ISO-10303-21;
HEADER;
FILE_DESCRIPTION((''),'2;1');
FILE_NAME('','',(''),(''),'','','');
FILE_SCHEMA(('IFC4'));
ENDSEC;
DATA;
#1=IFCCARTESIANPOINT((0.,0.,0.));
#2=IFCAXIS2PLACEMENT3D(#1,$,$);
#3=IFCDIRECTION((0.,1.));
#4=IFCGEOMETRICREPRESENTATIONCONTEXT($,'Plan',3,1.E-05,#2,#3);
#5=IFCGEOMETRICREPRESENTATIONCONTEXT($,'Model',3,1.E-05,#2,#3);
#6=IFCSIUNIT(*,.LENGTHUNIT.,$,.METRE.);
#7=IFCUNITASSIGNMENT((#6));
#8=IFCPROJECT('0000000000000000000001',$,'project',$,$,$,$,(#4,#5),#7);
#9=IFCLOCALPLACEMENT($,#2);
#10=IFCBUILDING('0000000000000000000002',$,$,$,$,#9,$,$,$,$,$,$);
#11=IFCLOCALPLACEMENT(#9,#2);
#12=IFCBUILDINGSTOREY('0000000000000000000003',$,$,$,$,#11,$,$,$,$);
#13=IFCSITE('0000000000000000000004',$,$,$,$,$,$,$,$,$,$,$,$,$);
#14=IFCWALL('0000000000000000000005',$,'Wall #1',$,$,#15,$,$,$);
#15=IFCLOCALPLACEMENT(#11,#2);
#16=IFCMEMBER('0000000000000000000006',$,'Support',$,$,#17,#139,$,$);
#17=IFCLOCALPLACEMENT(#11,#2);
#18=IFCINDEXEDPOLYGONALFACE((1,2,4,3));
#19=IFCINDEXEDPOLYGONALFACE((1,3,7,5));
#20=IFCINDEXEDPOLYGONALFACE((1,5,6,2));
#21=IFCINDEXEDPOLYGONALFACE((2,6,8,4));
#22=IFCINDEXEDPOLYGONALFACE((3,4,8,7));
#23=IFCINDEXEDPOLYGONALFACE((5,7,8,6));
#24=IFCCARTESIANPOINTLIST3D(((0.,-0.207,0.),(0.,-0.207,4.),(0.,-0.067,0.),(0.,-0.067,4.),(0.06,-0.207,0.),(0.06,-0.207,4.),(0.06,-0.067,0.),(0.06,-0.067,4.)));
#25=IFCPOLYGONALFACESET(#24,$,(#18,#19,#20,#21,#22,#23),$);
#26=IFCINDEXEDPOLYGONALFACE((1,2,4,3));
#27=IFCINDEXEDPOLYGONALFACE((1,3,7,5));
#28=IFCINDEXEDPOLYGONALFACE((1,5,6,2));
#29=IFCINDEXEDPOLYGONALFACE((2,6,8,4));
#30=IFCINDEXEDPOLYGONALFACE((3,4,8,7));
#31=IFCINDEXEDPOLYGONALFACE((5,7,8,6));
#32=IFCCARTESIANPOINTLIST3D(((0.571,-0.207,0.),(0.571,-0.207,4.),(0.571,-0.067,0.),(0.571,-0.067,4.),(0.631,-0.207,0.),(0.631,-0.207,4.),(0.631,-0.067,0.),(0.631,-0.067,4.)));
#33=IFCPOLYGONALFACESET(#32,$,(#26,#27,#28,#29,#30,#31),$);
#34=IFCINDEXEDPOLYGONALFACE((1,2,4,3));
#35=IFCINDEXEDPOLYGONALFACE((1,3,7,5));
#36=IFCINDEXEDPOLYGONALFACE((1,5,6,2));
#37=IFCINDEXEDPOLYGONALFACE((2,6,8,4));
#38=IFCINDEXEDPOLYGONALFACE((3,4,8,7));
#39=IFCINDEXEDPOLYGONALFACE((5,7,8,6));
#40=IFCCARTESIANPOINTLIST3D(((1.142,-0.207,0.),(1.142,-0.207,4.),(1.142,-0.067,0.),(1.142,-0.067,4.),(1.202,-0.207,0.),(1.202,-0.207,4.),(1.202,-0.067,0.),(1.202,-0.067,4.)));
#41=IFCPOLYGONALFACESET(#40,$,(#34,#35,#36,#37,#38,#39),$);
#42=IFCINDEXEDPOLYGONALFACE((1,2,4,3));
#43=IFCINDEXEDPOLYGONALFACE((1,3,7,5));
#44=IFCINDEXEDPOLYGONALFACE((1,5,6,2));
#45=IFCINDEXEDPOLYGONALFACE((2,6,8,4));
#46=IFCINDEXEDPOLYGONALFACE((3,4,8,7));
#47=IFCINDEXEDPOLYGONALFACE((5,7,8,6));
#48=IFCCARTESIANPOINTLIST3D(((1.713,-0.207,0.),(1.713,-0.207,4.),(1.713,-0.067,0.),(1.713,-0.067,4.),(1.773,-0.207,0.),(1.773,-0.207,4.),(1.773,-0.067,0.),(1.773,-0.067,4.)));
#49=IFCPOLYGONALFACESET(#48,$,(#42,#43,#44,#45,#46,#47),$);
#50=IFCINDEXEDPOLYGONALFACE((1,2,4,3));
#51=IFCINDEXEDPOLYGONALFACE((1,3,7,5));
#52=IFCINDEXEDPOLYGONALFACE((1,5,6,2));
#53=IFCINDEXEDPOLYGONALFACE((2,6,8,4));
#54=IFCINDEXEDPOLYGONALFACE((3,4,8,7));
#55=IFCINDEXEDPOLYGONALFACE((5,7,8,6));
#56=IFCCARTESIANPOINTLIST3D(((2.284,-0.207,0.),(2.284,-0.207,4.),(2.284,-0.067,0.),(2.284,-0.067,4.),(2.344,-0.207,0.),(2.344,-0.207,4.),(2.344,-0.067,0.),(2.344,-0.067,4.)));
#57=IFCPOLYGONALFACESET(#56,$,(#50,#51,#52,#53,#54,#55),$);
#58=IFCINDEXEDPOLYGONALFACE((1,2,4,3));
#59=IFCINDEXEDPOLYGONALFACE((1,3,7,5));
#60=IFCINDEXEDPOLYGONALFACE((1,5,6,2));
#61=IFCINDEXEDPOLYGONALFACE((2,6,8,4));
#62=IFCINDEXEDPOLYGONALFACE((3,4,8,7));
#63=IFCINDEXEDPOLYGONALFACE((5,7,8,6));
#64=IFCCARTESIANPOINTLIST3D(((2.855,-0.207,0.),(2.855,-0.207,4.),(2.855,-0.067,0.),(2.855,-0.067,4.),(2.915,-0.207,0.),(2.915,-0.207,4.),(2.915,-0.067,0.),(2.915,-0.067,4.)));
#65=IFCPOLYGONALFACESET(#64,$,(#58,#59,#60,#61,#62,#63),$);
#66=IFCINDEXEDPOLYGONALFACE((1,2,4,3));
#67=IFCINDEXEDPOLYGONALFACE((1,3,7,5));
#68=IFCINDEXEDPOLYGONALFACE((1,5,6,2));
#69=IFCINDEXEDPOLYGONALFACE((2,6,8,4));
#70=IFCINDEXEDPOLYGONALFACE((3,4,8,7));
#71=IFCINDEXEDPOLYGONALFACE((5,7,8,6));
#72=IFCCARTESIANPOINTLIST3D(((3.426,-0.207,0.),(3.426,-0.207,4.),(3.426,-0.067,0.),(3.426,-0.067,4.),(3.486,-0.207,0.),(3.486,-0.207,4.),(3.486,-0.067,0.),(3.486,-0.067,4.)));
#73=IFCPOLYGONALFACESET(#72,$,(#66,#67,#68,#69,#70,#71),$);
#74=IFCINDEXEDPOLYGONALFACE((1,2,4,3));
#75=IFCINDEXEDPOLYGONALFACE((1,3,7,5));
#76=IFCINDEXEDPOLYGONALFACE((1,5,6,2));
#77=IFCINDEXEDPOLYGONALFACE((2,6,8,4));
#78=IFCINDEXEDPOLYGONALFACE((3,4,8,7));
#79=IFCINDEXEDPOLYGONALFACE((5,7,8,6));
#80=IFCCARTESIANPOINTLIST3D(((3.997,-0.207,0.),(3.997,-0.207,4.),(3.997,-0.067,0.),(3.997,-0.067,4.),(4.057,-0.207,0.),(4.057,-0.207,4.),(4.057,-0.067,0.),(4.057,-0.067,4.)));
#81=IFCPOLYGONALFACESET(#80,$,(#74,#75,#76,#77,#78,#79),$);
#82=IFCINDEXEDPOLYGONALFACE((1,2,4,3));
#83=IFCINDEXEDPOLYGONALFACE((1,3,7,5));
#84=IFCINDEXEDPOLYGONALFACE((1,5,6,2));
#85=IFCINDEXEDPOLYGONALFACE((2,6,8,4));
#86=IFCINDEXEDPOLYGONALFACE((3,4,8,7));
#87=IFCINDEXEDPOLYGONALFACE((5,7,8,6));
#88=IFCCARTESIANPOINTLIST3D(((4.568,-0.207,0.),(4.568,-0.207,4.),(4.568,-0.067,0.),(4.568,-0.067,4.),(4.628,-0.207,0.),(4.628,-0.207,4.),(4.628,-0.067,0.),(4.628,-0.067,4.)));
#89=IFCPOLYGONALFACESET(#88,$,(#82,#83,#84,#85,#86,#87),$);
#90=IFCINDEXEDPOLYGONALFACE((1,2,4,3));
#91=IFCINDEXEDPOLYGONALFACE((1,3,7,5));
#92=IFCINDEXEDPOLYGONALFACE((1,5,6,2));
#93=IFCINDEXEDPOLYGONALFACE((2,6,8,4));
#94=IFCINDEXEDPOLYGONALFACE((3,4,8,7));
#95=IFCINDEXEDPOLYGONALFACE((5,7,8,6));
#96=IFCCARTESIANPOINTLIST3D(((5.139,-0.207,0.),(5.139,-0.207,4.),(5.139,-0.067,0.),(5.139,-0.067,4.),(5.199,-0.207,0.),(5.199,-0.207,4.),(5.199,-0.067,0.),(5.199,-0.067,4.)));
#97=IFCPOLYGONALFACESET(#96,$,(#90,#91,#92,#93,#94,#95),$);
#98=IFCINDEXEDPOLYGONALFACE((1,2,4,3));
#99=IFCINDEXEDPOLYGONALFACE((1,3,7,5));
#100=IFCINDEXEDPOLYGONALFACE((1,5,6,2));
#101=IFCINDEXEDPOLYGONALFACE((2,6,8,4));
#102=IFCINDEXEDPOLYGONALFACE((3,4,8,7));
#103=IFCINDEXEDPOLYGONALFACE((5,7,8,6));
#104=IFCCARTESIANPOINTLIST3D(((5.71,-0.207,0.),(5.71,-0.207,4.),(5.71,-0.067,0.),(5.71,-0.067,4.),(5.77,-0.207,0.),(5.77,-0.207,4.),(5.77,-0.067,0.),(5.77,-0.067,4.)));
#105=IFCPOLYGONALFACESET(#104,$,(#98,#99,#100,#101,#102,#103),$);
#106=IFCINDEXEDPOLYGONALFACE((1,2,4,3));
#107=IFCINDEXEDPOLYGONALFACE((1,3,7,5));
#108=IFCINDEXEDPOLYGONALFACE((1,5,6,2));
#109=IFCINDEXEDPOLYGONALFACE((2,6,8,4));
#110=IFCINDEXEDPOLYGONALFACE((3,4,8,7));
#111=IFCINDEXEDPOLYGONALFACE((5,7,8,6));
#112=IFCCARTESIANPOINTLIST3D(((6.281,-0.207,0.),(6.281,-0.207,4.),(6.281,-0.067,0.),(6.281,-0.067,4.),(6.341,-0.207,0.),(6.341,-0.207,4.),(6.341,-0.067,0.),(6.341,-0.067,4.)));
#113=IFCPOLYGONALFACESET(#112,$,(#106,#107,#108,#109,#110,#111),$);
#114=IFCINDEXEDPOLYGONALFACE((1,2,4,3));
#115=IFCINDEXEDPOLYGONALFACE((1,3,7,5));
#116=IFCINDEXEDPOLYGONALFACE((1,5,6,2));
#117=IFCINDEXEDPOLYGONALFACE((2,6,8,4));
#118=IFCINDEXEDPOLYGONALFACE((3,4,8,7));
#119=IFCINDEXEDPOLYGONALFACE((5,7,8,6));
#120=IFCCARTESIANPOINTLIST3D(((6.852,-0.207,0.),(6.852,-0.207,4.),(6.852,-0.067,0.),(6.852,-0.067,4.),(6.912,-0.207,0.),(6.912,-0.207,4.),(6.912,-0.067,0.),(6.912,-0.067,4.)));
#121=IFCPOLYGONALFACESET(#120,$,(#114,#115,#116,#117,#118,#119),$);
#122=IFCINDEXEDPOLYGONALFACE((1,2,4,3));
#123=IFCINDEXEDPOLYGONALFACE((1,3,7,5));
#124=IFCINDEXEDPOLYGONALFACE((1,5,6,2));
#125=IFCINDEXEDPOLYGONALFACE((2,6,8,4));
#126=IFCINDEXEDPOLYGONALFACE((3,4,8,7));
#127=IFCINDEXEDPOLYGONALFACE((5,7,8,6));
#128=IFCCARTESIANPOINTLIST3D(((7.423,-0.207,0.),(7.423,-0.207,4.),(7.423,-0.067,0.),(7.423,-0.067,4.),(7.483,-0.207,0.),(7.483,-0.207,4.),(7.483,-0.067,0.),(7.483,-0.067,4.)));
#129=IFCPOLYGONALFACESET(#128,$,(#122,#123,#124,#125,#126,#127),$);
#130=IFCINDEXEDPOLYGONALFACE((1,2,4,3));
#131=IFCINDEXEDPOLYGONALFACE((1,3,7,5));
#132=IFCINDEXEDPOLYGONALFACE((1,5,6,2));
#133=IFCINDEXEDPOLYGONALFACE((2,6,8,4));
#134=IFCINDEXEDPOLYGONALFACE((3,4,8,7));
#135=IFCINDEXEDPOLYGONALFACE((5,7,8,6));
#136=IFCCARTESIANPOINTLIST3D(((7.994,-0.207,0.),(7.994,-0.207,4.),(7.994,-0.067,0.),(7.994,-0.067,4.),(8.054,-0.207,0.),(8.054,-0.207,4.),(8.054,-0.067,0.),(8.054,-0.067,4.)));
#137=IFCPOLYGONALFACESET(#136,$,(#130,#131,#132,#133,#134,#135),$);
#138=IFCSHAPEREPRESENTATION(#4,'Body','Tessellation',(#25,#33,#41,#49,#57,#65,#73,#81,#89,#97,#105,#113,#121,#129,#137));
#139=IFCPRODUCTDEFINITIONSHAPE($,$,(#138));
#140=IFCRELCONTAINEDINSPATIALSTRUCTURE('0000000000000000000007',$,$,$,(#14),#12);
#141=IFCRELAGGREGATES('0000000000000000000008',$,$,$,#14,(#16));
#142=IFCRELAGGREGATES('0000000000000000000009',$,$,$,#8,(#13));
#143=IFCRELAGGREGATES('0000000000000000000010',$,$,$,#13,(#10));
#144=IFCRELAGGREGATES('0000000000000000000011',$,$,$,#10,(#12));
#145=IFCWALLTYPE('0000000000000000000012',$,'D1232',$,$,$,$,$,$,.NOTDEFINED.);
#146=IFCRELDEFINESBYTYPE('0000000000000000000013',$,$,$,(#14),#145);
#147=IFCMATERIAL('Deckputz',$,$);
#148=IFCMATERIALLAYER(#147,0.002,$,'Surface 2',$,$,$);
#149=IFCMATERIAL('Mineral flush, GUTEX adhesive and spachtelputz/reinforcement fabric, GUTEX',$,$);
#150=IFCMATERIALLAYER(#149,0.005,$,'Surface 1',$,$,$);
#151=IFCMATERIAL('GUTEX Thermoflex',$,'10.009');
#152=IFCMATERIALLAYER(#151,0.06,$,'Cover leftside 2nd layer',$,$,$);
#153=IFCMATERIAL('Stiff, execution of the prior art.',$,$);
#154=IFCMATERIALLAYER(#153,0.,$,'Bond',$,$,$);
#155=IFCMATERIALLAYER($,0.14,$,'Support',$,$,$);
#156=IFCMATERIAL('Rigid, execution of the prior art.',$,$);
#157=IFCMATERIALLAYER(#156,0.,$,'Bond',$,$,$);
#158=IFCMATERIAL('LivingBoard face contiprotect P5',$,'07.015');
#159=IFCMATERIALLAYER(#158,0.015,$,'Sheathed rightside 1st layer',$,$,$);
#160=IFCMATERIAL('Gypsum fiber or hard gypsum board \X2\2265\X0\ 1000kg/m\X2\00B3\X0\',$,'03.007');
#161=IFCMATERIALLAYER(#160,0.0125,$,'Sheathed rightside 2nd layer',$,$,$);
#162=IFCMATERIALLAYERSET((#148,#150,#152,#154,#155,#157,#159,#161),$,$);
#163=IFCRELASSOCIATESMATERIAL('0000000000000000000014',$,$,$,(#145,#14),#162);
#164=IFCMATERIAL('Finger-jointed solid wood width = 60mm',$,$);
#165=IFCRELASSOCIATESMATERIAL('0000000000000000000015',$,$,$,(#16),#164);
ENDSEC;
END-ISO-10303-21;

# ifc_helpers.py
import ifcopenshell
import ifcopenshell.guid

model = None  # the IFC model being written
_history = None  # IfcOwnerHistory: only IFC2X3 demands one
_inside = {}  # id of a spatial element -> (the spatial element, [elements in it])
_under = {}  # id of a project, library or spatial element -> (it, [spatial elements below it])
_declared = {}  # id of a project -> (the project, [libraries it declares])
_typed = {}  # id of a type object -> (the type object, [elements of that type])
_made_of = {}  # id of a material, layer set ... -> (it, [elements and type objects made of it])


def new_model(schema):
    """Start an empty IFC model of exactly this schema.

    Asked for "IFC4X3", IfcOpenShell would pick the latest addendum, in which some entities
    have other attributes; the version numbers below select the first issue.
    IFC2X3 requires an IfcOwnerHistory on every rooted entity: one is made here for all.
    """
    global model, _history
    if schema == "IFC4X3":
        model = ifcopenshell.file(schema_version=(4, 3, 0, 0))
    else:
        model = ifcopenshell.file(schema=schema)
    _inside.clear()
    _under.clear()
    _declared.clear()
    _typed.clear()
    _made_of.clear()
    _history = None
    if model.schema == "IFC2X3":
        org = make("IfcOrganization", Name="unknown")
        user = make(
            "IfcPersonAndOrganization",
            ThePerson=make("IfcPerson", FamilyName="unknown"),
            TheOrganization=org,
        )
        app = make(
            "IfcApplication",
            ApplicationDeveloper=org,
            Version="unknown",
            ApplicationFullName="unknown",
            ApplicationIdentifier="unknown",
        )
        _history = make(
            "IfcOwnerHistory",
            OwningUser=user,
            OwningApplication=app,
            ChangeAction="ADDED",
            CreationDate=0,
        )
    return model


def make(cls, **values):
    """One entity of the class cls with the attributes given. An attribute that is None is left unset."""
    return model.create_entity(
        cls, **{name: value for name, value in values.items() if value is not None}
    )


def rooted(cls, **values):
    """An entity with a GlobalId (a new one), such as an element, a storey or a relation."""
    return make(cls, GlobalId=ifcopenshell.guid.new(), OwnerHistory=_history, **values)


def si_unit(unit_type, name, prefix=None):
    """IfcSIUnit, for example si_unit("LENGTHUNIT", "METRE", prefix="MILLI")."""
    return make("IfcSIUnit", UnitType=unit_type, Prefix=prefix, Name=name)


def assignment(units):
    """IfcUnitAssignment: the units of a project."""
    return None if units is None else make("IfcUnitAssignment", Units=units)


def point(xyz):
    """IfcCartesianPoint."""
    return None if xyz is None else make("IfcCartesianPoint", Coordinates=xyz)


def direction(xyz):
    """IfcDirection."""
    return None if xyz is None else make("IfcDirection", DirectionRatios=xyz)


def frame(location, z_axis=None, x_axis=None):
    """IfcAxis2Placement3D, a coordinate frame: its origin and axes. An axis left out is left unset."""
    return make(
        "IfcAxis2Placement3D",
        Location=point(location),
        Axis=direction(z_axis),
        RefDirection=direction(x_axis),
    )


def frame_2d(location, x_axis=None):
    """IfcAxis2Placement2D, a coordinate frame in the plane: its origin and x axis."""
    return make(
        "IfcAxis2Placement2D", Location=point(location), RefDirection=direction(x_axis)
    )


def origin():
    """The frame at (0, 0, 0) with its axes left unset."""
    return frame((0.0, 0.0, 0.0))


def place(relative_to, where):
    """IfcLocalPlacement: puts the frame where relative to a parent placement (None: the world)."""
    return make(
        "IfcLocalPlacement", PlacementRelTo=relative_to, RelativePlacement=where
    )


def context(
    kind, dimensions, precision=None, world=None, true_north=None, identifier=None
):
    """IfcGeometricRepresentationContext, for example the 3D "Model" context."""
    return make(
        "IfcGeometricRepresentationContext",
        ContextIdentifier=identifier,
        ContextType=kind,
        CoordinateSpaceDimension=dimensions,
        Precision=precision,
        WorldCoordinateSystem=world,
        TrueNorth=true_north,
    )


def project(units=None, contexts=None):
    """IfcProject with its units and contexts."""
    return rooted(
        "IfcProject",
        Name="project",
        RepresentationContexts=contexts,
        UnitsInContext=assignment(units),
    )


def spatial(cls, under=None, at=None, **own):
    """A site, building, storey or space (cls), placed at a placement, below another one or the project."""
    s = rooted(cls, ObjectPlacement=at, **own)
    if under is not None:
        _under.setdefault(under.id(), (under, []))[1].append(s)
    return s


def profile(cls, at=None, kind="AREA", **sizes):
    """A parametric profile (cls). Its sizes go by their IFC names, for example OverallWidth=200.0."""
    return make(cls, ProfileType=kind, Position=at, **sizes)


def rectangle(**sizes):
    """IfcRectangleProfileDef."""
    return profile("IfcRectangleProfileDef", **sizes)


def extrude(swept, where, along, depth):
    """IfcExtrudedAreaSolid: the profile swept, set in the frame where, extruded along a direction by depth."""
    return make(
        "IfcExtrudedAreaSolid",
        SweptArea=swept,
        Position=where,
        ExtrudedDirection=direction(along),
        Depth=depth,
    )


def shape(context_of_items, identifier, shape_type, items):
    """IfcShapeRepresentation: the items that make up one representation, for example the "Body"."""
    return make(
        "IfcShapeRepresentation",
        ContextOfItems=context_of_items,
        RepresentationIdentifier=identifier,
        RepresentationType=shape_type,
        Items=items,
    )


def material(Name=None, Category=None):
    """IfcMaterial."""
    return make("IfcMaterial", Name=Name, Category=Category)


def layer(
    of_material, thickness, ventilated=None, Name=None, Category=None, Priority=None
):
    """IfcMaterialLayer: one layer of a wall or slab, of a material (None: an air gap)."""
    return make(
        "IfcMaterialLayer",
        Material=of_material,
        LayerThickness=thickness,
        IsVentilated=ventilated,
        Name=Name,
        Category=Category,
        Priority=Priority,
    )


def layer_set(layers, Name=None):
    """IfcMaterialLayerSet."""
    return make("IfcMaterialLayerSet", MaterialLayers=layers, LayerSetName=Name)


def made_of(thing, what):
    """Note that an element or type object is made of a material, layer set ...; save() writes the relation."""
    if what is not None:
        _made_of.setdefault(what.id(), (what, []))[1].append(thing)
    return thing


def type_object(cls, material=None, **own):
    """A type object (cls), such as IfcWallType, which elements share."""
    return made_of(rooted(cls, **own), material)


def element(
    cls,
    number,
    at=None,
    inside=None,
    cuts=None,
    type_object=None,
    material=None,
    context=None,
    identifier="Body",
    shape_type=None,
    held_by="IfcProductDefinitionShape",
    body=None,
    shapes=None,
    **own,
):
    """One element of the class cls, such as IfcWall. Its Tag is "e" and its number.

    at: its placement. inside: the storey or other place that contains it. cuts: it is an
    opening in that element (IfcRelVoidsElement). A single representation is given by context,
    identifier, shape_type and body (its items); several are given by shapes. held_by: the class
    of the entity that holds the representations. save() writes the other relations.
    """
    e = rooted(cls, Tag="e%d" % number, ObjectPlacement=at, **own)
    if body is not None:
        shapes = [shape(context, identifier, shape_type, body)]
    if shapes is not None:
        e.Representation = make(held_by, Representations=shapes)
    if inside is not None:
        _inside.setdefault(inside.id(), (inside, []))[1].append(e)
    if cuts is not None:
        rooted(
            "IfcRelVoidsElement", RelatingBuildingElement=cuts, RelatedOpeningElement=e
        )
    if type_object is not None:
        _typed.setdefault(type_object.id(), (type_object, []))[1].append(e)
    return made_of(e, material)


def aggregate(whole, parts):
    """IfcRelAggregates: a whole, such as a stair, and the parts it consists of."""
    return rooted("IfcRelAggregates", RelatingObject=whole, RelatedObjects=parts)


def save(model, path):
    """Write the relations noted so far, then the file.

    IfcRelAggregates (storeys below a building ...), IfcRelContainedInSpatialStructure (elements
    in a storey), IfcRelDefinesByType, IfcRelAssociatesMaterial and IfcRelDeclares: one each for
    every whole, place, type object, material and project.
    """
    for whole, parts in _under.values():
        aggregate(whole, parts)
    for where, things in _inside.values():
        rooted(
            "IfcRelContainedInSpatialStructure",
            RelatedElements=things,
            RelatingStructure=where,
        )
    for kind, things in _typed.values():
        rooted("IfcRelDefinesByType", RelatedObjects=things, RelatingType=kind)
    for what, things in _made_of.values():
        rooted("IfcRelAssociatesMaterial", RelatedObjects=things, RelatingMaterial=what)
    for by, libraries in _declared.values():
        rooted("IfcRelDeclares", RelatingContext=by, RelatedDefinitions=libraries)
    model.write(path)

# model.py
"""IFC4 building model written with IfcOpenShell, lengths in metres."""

from ifc_helpers import new_model, si_unit, direction, frame, frame_2d, origin, place, context, project, spatial, rectangle, extrude, material, layer, layer_set, type_object, element, aggregate, save


model = new_model("IFC4")

# Units and contexts
plan_context = context("Plan", 3, precision=1e-05, world=origin(), true_north=direction((0.0, 1.0)))
model_context = context("Model", 3, precision=1e-05, world=origin(), true_north=direction((0.0, 1.0)))
ifc_project = project(units=[si_unit("LENGTHUNIT", "METRE")], contexts=[plan_context, model_context])

# Site, building, storey
site = spatial("IfcSite", under=ifc_project)
building_placement = place(None, origin())
building = spatial("IfcBuilding", under=site, at=building_placement)
storey_placement = place(building_placement, origin())
storey = spatial("IfcBuildingStorey", under=building, at=storey_placement)

# Wall, member
ifc_material_1 = material(Name="Deckputz")
ifc_layer_1 = layer(ifc_material_1, 0.002, Name="Surface 2")
ifc_material_2 = material(Name="Mineral flush, GUTEX adhesive and spachtelputz/reinforcement fabric, GUTEX")
ifc_layer_2 = layer(ifc_material_2, 0.005, Name="Surface 1")
ifc_material_3 = material(Name="GUTEX Thermoflex", Category="10.009")
ifc_layer_3 = layer(ifc_material_3, 0.06, Name="Cover leftside 2nd layer")
ifc_material_4 = material(Name="Stiff, execution of the prior art.")
ifc_layer_4 = layer(ifc_material_4, 0.0, Name="Bond")
ifc_layer_5 = layer(None, 0.14, Name="Support")
ifc_material_5 = material(Name="Rigid, execution of the prior art.")
ifc_layer_6 = layer(ifc_material_5, 0.0, Name="Bond")
ifc_material_6 = material(Name="LivingBoard face contiprotect P5", Category="07.015")
ifc_layer_7 = layer(ifc_material_6, 0.015, Name="Sheathed rightside 1st layer")
ifc_material_7 = material(Name="Gypsum fiber or hard gypsum board ≥ 1000kg/m³", Category="03.007")
ifc_layer_8 = layer(ifc_material_7, 0.0125, Name="Sheathed rightside 2nd layer")
ifc_layer_set = layer_set([ifc_layer_1, ifc_layer_2, ifc_layer_3, ifc_layer_4, ifc_layer_5, ifc_layer_6, ifc_layer_7, ifc_layer_8])
wall_type = type_object("IfcWallType", Name="D1232", PredefinedType="NOTDEFINED", material=ifc_layer_set)
wall_placement = place(None, frame((0.0, 0.0, 0.0), z_axis=(0.0, -1.0, 0.0), x_axis=(1.0, 0.0, 0.0)))
wall = element("IfcWall", 1, at=wall_placement, inside=storey, type_object=wall_type, material=ifc_layer_set, Name="Wall #1")
ifc_material_8 = material(Name="Finger-jointed solid wood width = 60mm")
member_1_placement = place(wall_placement, origin())
member_1 = element("IfcMember", 2, at=member_1_placement, material=ifc_material_8, Name="Support", context=plan_context, shape_type="SweptSolid", body=[
    extrude(rectangle(XDim=0.06, YDim=0.14, at=frame_2d((0.03, 0.07), x_axis=(1.0, 0.0))), frame((0.0, 4.0, 0.067), z_axis=(0.0, -1.0, 0.0), x_axis=(1.0, 0.0, 0.0)), (0.0, 0.0, 1.0), 4.0),
    extrude(rectangle(XDim=0.06, YDim=0.14, at=frame_2d((0.03, 0.07), x_axis=(1.0, 0.0))), frame((0.571, 4.0, 0.067), z_axis=(0.0, -1.0, 0.0), x_axis=(1.0, 0.0, 0.0)), (0.0, 0.0, 1.0), 4.0),
    extrude(rectangle(XDim=0.06, YDim=0.14, at=frame_2d((0.03, 0.07), x_axis=(1.0, 0.0))), frame((1.142, 4.0, 0.067), z_axis=(0.0, -1.0, 0.0), x_axis=(1.0, 0.0, 0.0)), (0.0, 0.0, 1.0), 4.0),
    extrude(rectangle(XDim=0.06, YDim=0.14, at=frame_2d((0.03, 0.07), x_axis=(1.0, 0.0))), frame((1.713, 4.0, 0.067), z_axis=(0.0, -1.0, 0.0), x_axis=(1.0, 0.0, 0.0)), (0.0, 0.0, 1.0), 4.0),
    extrude(rectangle(XDim=0.06, YDim=0.14, at=frame_2d((0.03, 0.07), x_axis=(1.0, 0.0))), frame((2.284, 4.0, 0.067), z_axis=(0.0, -1.0, 0.0), x_axis=(1.0, 0.0, 0.0)), (0.0, 0.0, 1.0), 4.0),
    extrude(rectangle(XDim=0.06, YDim=0.14, at=frame_2d((0.03, 0.07), x_axis=(1.0, 0.0))), frame((2.855, 4.0, 0.067), z_axis=(0.0, -1.0, 0.0), x_axis=(1.0, 0.0, 0.0)), (0.0, 0.0, 1.0), 4.0),
    extrude(rectangle(XDim=0.06, YDim=0.14, at=frame_2d((0.03, 0.07), x_axis=(1.0, 0.0))), frame((3.426, 4.0, 0.067), z_axis=(0.0, -1.0, 0.0), x_axis=(1.0, 0.0, 0.0)), (0.0, 0.0, 1.0), 4.0),
    extrude(rectangle(XDim=0.06, YDim=0.14, at=frame_2d((0.03, 0.07), x_axis=(1.0, 0.0))), frame((3.997, 4.0, 0.067), z_axis=(0.0, -1.0, 0.0), x_axis=(1.0, 0.0, 0.0)), (0.0, 0.0, 1.0), 4.0),
    extrude(rectangle(XDim=0.06, YDim=0.14, at=frame_2d((0.03, 0.07), x_axis=(1.0, 0.0))), frame((4.568, 4.0, 0.067), z_axis=(0.0, -1.0, 0.0), x_axis=(1.0, 0.0, 0.0)), (0.0, 0.0, 1.0), 4.0),
    extrude(rectangle(XDim=0.06, YDim=0.14, at=frame_2d((0.03, 0.07), x_axis=(1.0, 0.0))), frame((5.139, 4.0, 0.067), z_axis=(0.0, -1.0, 0.0), x_axis=(1.0, 0.0, 0.0)), (0.0, 0.0, 1.0), 4.0),
    extrude(rectangle(XDim=0.06, YDim=0.14, at=frame_2d((0.03, 0.07), x_axis=(1.0, 0.0))), frame((5.71, 4.0, 0.067), z_axis=(0.0, -1.0, 0.0), x_axis=(1.0, 0.0, 0.0)), (0.0, 0.0, 1.0), 4.0),
    extrude(rectangle(XDim=0.06, YDim=0.14, at=frame_2d((0.03, 0.07), x_axis=(1.0, 0.0))), frame((6.281, 4.0, 0.067), z_axis=(0.0, -1.0, 0.0), x_axis=(1.0, 0.0, 0.0)), (0.0, 0.0, 1.0), 4.0),
    extrude(rectangle(XDim=0.06, YDim=0.14, at=frame_2d((0.03, 0.07), x_axis=(1.0, 0.0))), frame((6.852, 4.0, 0.067), z_axis=(0.0, -1.0, 0.0), x_axis=(1.0, 0.0, 0.0)), (0.0, 0.0, 1.0), 4.0),
    extrude(rectangle(XDim=0.06, YDim=0.14, at=frame_2d((0.03, 0.07), x_axis=(1.0, 0.0))), frame((7.423, 4.0, 0.067), z_axis=(0.0, -1.0, 0.0), x_axis=(1.0, 0.0, 0.0)), (0.0, 0.0, 1.0), 4.0),
    extrude(rectangle(XDim=0.06, YDim=0.14, at=frame_2d((0.03, 0.07), x_axis=(1.0, 0.0))), frame((7.994, 4.0, 0.067), z_axis=(0.0, -1.0, 0.0), x_axis=(1.0, 0.0, 0.0)), (0.0, 0.0, 1.0), 4.0),
])
aggregate(wall, [member_1])

save(model, "model.ifc")
